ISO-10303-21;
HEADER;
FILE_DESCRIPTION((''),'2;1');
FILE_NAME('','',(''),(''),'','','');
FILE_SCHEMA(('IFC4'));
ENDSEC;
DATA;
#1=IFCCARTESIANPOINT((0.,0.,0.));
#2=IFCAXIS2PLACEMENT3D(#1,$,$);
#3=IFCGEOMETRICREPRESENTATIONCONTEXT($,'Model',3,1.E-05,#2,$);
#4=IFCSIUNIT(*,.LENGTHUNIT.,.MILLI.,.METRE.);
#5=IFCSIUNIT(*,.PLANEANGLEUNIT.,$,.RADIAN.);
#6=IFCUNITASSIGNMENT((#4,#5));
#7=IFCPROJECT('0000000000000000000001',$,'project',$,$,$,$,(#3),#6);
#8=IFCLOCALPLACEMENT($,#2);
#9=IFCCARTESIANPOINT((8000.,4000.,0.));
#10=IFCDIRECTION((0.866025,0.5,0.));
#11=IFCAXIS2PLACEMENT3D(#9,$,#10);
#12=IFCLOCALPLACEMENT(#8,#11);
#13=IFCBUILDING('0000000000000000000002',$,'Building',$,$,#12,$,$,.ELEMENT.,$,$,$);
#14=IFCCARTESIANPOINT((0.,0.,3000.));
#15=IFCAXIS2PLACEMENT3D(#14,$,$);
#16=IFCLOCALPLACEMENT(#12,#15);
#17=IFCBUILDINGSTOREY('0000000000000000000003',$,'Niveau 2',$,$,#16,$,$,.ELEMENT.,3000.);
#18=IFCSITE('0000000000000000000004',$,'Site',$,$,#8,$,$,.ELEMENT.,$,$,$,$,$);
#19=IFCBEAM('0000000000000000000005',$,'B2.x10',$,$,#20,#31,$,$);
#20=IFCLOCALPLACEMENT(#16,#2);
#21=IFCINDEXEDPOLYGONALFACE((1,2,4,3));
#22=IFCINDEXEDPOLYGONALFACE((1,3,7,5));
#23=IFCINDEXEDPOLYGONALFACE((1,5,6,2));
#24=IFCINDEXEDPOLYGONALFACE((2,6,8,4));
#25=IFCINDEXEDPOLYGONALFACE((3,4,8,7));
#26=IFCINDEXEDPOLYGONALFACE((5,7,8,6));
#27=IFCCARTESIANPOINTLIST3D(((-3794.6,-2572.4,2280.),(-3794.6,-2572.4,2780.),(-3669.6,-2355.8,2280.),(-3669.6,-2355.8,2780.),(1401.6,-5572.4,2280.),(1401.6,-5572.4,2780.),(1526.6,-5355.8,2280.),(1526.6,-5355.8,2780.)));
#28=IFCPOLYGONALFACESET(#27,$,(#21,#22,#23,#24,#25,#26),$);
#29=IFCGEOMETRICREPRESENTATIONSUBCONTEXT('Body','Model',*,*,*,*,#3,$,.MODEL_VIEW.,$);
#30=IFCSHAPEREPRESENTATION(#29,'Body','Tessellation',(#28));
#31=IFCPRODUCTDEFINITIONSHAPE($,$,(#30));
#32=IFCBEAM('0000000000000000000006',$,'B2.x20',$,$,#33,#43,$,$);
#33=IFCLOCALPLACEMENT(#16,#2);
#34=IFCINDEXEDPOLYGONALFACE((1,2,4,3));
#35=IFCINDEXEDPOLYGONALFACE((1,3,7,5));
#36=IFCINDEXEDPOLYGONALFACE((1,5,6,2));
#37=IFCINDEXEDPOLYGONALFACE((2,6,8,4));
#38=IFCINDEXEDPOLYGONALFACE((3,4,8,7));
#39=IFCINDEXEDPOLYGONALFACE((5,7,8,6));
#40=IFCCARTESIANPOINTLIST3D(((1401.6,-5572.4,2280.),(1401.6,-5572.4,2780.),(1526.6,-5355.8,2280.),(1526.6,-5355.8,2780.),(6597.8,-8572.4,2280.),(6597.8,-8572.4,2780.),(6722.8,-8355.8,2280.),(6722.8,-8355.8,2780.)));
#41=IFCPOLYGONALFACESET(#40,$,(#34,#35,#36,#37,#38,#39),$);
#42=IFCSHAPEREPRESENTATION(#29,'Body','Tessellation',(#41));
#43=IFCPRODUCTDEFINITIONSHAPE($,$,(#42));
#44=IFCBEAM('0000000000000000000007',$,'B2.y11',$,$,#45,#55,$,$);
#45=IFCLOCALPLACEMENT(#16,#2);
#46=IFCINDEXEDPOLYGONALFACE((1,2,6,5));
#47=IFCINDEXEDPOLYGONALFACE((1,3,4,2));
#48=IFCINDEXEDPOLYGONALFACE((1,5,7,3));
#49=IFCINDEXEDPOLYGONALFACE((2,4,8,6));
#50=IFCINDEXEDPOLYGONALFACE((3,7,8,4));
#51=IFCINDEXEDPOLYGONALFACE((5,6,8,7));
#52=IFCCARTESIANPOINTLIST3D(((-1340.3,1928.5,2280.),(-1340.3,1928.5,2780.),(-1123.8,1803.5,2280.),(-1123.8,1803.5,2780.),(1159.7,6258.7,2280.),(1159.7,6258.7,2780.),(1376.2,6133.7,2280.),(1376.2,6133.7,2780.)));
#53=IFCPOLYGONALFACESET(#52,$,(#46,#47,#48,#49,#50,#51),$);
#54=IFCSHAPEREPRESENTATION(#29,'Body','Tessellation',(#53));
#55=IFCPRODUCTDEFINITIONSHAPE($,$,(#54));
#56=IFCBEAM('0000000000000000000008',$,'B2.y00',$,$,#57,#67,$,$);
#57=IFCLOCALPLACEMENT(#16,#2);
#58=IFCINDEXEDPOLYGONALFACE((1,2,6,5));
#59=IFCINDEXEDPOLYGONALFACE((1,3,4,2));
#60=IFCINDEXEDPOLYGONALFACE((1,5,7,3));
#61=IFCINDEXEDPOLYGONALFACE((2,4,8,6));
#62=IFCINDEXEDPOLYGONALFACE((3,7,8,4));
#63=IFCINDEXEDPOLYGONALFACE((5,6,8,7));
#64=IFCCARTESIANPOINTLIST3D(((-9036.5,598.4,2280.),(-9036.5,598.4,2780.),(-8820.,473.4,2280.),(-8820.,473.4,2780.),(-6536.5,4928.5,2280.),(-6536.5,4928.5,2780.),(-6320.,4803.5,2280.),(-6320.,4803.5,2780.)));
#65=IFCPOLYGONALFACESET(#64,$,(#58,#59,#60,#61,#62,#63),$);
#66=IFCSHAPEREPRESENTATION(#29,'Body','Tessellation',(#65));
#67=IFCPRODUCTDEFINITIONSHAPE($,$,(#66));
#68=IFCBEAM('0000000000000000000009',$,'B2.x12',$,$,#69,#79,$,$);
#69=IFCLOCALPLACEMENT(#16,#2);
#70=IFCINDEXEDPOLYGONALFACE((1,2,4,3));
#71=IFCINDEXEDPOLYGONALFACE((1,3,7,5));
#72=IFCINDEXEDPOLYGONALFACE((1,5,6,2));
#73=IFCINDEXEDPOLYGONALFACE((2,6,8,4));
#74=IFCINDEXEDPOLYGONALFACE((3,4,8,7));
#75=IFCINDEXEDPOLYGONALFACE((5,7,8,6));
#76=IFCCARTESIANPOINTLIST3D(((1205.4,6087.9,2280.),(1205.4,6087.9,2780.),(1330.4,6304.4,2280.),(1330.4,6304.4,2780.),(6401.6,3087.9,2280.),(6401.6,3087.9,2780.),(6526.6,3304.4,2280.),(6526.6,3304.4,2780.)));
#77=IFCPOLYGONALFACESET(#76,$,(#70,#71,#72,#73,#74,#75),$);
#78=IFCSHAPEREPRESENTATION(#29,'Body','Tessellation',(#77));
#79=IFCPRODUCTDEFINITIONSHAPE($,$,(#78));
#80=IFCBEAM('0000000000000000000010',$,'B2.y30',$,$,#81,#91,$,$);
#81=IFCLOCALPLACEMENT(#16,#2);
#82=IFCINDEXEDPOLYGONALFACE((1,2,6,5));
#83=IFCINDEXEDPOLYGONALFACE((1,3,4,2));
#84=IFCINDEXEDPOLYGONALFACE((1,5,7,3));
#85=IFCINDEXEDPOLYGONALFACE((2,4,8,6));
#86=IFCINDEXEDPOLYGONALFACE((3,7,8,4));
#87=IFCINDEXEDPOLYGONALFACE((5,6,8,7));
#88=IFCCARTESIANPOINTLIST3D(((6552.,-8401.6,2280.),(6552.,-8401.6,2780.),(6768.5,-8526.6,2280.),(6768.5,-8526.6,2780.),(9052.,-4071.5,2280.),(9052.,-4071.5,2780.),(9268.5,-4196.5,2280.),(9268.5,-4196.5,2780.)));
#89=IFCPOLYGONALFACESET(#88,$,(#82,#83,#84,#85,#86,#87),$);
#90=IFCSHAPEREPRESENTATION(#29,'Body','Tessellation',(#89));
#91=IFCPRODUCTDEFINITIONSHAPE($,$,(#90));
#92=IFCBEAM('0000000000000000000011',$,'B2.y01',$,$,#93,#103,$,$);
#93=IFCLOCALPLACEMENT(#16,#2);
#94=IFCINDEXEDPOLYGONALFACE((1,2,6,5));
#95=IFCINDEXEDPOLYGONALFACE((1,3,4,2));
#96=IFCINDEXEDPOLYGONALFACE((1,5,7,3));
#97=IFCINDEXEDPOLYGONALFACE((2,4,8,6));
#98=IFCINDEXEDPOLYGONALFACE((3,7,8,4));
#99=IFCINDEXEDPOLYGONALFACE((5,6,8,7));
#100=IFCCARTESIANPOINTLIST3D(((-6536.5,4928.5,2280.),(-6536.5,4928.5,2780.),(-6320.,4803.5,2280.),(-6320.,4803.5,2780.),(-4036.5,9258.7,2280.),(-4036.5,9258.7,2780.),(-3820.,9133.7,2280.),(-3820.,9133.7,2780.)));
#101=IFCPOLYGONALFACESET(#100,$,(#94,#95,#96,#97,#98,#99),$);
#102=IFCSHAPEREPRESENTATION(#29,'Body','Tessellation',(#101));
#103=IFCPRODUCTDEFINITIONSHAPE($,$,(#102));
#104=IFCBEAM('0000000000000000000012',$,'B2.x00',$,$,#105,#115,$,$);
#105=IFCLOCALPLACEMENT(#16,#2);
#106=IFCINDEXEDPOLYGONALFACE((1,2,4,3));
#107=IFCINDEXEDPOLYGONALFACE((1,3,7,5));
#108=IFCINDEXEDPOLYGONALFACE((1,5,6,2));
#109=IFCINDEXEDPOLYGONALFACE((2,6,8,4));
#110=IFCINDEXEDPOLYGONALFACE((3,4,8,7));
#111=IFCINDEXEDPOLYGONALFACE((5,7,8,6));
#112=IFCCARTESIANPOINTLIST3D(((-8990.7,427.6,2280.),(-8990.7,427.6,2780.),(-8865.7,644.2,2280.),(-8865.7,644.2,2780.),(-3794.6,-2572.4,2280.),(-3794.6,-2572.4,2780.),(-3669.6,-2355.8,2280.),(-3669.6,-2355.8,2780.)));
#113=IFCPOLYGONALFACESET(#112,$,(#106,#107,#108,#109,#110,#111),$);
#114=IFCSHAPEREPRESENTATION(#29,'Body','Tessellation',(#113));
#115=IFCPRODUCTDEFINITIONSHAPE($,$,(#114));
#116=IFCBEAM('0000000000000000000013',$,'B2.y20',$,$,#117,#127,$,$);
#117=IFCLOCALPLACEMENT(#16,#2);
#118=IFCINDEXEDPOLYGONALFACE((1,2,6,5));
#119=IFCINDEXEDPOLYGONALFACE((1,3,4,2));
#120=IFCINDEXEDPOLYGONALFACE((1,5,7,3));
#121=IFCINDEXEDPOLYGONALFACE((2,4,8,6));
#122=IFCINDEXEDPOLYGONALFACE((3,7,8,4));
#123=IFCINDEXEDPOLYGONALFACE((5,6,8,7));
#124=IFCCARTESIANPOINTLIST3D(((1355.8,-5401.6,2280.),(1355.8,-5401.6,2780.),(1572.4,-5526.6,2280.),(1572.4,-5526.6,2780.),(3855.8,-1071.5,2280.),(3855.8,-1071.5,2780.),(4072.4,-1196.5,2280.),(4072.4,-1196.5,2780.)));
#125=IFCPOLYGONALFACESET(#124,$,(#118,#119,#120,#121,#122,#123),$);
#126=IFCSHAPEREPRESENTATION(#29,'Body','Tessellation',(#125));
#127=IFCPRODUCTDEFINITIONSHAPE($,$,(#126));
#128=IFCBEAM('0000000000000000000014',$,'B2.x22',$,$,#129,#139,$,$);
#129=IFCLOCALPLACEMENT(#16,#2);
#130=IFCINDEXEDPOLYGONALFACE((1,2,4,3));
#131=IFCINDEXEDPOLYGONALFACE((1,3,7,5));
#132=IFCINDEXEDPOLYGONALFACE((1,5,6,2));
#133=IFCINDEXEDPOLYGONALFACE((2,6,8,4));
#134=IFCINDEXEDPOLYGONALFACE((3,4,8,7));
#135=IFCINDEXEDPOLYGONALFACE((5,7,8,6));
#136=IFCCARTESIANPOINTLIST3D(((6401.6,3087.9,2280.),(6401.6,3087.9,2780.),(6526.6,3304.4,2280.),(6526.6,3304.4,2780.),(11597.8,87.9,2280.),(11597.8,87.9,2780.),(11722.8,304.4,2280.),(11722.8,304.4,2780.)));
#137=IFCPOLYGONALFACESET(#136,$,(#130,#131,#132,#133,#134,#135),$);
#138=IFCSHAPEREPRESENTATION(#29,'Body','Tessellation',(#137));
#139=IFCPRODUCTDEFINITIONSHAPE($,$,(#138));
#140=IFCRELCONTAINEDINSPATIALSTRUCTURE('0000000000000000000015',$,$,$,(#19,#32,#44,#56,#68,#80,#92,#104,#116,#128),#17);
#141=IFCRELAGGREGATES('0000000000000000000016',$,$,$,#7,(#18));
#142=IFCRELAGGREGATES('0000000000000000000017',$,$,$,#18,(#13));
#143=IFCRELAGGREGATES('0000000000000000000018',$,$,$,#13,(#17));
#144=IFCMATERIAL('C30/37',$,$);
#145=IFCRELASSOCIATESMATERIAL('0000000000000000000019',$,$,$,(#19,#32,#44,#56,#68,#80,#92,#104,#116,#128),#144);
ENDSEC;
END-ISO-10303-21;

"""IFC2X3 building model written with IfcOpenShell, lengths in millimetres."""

from ifc_helpers import new_model, si_unit, frame, origin, origin_2d, place, context, subcontext, project, spatial, rectangle, extrude, material, element, save


model = new_model("IFC2X3")

# Units and contexts
model_context = context("Model", 3, precision=1e-05, world=origin())
body_context = subcontext(model_context, "Body", "Model", "MODEL_VIEW")
ifc_project = project(units=[si_unit("LENGTHUNIT", "METRE", prefix="MILLI"), si_unit("PLANEANGLEUNIT", "RADIAN")], contexts=[model_context])

# Site, building, storey
site_placement = place(None, origin())
site = spatial("IfcSite", under=ifc_project, at=site_placement, Name="Site", CompositionType="ELEMENT")
building_placement = place(site_placement, frame((8000.0, 4000.0, 0.0), x_axis=(0.866025, 0.5, 0.0)))
building = spatial("IfcBuilding", under=site, at=building_placement, Name="Building", CompositionType="ELEMENT")
storey_placement = place(building_placement, frame((0.0, 0.0, 3000.0)))
storey = spatial("IfcBuildingStorey", under=building, at=storey_placement, Name="Niveau 2", CompositionType="ELEMENT", Elevation=3000.0)

# Shared definitions
ifc_material = material(Name="C30/37")

# Beams
for number, where, z_axis, x_axis, name in (
    (1, (-3732.1, -2464.1, 2530.0), (0.866025, -0.5, 0.0), (0.5, 0.866025, 0.0), "B2.x10"),
    (2, (1464.1, -5464.1, 2530.0), (0.866025, -0.5, 0.0), (0.5, 0.866025, 0.0), "B2.x20"),
):
    element("IfcBeam", number, at=place(storey_placement, frame(where, z_axis=z_axis, x_axis=x_axis)), inside=storey, material=ifc_material, Name=name, context=body_context, shape_type="SweptSolid", body=[
        extrude(rectangle(XDim=250.0, YDim=500.0, at=origin_2d()), origin(), (0.0, 0.0, 1.0), 6000.0),
    ])
for number, where, z_axis, x_axis, name in (
    (3, (-1232.1, 1866.0, 2530.0), (0.5, 0.866025, 0.0), (-0.866025, 0.5, 0.0), "B2.y11"),
    (4, (-8928.2, 535.9, 2530.0), (0.5, 0.866025, 0.0), (-0.866025, 0.5, 0.0), "B2.y00"),
):
    element("IfcBeam", number, at=place(storey_placement, frame(where, z_axis=z_axis, x_axis=x_axis)), inside=storey, material=ifc_material, Name=name, context=body_context, shape_type="SweptSolid", body=[
        extrude(rectangle(XDim=250.0, YDim=500.0, at=origin_2d()), origin(), (0.0, 0.0, 1.0), 5000.0),
    ])
beam_1_placement = place(storey_placement, frame((1267.9, 6196.2, 2530.0), z_axis=(0.866025, -0.5, 0.0), x_axis=(0.5, 0.866025, 0.0)))
element("IfcBeam", 5, at=beam_1_placement, inside=storey, material=ifc_material, Name="B2.x12", context=body_context, shape_type="SweptSolid", body=[
    extrude(rectangle(XDim=250.0, YDim=500.0, at=origin_2d()), origin(), (0.0, 0.0, 1.0), 6000.0),
])
for number, where, z_axis, x_axis, name in (
    (6, (6660.3, -8464.1, 2530.0), (0.5, 0.866025, 0.0), (-0.866025, 0.5, 0.0), "B2.y30"),
    (7, (-6428.2, 4866.0, 2530.0), (0.5, 0.866025, 0.0), (-0.866025, 0.5, 0.0), "B2.y01"),
):
    element("IfcBeam", number, at=place(storey_placement, frame(where, z_axis=z_axis, x_axis=x_axis)), inside=storey, material=ifc_material, Name=name, context=body_context, shape_type="SweptSolid", body=[
        extrude(rectangle(XDim=250.0, YDim=500.0, at=origin_2d()), origin(), (0.0, 0.0, 1.0), 5000.0),
    ])
beam_2_placement = place(storey_placement, frame((-8928.2, 535.9, 2530.0), z_axis=(0.866025, -0.5, 0.0), x_axis=(0.5, 0.866025, 0.0)))
element("IfcBeam", 8, at=beam_2_placement, inside=storey, material=ifc_material, Name="B2.x00", context=body_context, shape_type="SweptSolid", body=[
    extrude(rectangle(XDim=250.0, YDim=500.0, at=origin_2d()), origin(), (0.0, 0.0, 1.0), 6000.0),
])
beam_3_placement = place(storey_placement, frame((1464.1, -5464.1, 2530.0), z_axis=(0.5, 0.866025, 0.0), x_axis=(-0.866025, 0.5, 0.0)))
element("IfcBeam", 9, at=beam_3_placement, inside=storey, material=ifc_material, Name="B2.y20", context=body_context, shape_type="SweptSolid", body=[
    extrude(rectangle(XDim=250.0, YDim=500.0, at=origin_2d()), origin(), (0.0, 0.0, 1.0), 5000.0),
])
beam_4_placement = place(storey_placement, frame((6464.1, 3196.2, 2530.0), z_axis=(0.866025, -0.5, 0.0), x_axis=(0.5, 0.866025, 0.0)))
element("IfcBeam", 10, at=beam_4_placement, inside=storey, material=ifc_material, Name="B2.x22", context=body_context, shape_type="SweptSolid", body=[
    extrude(rectangle(XDim=250.0, YDim=500.0, at=origin_2d()), origin(), (0.0, 0.0, 1.0), 6000.0),
])

save(model, "model.ifc")
